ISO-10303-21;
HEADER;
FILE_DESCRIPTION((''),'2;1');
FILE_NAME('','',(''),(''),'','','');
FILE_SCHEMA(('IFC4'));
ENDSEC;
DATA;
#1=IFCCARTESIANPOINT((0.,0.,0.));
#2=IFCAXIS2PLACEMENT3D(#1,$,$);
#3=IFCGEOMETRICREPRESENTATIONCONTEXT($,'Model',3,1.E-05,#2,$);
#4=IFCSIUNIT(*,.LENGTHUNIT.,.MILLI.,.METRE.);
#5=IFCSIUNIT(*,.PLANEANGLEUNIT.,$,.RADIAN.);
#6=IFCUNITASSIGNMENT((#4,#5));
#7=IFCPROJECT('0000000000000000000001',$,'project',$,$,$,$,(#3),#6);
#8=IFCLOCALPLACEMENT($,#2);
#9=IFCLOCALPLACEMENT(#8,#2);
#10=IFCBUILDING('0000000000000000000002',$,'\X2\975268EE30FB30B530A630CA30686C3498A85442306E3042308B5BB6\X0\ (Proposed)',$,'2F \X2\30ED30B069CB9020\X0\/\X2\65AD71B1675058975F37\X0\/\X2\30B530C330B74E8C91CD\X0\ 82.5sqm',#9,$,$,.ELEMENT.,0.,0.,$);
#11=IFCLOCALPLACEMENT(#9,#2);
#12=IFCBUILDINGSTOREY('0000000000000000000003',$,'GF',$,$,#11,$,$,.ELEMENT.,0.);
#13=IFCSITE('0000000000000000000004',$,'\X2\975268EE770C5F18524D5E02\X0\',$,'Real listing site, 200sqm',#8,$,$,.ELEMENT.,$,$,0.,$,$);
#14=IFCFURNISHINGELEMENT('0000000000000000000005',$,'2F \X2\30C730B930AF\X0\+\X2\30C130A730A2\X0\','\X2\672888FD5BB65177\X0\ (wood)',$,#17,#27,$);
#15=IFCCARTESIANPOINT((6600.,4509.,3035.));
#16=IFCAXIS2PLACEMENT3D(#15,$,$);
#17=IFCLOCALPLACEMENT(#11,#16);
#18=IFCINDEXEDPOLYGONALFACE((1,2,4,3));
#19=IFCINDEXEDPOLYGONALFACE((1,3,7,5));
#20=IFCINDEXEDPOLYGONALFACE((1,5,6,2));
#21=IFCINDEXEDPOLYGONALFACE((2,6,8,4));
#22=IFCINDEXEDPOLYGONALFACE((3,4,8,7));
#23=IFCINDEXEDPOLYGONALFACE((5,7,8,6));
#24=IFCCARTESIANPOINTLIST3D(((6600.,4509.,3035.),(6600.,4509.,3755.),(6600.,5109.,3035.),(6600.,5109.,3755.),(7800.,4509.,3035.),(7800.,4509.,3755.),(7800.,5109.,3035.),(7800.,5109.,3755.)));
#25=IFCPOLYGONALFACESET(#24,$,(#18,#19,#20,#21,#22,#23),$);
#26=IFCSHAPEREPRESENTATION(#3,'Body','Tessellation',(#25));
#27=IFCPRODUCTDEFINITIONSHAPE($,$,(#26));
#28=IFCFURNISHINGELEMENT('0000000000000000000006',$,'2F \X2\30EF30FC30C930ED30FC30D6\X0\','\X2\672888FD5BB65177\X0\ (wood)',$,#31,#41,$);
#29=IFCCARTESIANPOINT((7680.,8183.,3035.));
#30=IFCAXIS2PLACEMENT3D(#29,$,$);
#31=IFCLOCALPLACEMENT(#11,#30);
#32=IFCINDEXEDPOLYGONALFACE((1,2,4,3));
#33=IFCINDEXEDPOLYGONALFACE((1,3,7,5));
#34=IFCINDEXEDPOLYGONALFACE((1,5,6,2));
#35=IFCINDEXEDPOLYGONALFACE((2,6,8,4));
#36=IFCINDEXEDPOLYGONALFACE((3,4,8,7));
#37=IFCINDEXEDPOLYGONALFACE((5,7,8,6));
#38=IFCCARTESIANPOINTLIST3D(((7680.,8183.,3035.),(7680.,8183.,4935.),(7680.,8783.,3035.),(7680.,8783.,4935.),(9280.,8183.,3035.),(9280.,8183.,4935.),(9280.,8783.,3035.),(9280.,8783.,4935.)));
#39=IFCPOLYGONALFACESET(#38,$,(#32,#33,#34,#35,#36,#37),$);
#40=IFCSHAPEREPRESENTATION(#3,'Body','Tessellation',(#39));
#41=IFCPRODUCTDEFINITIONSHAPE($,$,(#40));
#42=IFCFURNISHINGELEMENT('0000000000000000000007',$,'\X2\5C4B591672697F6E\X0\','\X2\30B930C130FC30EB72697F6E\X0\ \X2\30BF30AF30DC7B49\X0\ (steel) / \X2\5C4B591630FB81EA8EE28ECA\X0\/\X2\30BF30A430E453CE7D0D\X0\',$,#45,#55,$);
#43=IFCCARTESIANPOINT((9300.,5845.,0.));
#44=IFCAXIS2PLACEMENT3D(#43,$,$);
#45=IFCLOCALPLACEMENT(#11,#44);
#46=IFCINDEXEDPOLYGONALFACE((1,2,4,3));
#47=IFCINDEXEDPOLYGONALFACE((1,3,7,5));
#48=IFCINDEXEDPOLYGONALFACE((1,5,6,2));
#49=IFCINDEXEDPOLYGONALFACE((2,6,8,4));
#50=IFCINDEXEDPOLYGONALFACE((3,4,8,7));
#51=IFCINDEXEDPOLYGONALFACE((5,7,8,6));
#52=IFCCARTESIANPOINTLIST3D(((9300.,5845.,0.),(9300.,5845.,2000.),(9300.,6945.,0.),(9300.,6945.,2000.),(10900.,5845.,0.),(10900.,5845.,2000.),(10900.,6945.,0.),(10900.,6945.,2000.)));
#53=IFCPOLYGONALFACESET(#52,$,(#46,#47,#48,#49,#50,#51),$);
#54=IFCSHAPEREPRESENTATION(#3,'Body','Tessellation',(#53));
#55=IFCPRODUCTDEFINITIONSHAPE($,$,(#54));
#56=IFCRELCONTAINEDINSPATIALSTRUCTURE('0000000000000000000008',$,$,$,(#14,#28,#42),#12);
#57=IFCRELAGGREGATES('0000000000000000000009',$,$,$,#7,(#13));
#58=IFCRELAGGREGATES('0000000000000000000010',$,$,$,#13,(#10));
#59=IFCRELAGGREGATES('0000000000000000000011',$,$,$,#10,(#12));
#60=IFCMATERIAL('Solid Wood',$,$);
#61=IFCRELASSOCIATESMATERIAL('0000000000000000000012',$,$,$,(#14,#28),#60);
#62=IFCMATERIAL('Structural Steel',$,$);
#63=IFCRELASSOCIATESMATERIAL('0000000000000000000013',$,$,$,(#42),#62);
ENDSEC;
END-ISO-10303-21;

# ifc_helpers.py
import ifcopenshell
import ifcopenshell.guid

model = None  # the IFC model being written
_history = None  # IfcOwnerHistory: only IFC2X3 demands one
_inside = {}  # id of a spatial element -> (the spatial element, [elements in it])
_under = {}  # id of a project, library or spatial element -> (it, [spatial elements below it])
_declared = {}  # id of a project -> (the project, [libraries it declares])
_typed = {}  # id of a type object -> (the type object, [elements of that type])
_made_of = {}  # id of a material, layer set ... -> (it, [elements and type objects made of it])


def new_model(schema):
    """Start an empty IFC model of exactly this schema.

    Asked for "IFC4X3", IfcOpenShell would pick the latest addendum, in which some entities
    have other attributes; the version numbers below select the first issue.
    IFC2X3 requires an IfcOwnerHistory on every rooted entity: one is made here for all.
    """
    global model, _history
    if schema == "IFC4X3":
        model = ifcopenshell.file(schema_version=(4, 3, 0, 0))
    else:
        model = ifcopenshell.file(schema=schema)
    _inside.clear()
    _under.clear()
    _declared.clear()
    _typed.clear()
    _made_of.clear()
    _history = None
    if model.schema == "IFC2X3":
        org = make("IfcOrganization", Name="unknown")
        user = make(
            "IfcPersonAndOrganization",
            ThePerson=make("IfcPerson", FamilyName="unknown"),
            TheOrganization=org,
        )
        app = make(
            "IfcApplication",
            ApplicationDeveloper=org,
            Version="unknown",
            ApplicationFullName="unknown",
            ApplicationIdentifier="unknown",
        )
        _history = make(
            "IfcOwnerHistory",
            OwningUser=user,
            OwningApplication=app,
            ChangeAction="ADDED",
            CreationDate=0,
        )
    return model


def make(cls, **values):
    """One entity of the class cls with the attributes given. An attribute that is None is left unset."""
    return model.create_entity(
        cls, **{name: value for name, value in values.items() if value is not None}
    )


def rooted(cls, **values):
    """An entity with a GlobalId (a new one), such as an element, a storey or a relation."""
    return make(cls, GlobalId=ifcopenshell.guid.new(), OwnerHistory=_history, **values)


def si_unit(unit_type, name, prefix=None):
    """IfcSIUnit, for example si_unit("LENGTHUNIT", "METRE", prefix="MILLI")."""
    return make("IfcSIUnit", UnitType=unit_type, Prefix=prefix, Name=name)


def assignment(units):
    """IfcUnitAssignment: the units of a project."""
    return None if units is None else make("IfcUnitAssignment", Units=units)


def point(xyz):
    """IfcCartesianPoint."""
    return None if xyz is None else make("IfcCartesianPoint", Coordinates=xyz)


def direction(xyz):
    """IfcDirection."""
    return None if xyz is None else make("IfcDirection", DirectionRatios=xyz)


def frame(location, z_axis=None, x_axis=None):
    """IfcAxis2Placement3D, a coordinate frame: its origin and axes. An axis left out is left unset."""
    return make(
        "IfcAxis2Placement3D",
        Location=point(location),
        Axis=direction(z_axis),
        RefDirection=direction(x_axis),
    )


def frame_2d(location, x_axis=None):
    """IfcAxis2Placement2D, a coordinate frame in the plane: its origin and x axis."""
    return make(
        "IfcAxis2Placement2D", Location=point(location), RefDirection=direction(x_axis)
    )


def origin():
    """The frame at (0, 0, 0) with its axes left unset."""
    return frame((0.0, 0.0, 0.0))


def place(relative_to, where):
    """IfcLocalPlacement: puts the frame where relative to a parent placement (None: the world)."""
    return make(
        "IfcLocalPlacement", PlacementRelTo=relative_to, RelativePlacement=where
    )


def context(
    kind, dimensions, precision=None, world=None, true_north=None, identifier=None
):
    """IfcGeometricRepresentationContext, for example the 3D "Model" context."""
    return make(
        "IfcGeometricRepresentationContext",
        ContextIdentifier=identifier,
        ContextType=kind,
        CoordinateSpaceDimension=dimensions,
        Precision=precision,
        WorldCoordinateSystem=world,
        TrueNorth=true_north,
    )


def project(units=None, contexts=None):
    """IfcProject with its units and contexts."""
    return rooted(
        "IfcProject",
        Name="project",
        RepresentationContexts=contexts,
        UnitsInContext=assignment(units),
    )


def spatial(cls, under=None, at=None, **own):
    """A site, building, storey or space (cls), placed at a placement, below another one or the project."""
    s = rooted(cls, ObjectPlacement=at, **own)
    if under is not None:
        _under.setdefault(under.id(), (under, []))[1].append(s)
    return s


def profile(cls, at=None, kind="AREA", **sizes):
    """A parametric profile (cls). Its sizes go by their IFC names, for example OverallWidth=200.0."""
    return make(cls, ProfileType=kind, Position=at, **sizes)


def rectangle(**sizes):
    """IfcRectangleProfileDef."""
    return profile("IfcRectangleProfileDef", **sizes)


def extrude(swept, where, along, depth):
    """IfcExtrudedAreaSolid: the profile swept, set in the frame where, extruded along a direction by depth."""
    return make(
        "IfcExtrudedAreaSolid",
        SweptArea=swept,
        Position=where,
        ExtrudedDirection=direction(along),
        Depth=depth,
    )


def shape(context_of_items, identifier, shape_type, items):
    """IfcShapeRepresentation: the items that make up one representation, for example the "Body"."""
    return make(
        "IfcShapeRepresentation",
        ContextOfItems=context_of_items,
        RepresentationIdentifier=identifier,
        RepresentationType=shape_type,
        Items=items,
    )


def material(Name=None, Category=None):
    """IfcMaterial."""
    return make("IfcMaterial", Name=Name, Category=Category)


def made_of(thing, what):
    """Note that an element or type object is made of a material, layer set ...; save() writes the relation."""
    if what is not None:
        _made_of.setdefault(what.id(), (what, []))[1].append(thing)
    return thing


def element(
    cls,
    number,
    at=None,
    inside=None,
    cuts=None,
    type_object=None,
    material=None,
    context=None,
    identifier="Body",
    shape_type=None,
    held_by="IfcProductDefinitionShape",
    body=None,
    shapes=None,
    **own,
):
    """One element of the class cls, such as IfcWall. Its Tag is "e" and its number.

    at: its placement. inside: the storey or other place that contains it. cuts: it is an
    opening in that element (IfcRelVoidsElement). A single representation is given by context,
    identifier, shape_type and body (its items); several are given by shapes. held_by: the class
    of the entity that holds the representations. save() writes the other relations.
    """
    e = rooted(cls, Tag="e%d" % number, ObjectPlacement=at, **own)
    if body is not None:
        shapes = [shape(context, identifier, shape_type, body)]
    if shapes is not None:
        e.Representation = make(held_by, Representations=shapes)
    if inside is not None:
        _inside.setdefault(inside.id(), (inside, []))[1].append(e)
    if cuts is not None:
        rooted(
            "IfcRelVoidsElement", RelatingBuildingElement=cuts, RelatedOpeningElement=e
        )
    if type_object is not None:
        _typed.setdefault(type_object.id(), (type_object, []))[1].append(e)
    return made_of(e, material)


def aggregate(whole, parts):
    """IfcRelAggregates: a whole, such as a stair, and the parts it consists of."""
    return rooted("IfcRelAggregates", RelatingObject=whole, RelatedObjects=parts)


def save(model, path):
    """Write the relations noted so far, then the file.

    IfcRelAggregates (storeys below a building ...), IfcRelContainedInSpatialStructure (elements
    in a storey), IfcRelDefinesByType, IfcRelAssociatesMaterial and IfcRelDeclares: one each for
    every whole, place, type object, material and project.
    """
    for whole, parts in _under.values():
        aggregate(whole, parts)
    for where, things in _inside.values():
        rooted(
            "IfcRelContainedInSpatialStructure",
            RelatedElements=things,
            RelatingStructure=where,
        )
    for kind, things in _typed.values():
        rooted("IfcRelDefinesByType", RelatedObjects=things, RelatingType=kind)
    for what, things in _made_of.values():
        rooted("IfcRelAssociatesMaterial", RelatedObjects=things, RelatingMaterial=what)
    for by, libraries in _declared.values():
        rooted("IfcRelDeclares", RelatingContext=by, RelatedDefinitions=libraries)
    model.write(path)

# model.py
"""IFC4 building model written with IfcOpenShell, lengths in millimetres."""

from ifc_helpers import new_model, si_unit, frame, frame_2d, origin, place, context, project, spatial, rectangle, extrude, material, element, save


model = new_model("IFC4")

# Units and contexts
model_context = context("Model", 3, precision=1e-05, world=origin())
ifc_project = project(units=[si_unit("LENGTHUNIT", "METRE", prefix="MILLI"), si_unit("PLANEANGLEUNIT", "RADIAN")], contexts=[model_context])

# Site, building, storey
site_placement = place(None, origin())
site = spatial("IfcSite", under=ifc_project, at=site_placement, Name="青森県弘前市", ObjectType="Real listing site, 200sqm", CompositionType="ELEMENT", RefElevation=0.0)
building_placement = place(site_placement, origin())
building = spatial("IfcBuilding", under=site, at=building_placement, Name="青森・サウナと水風呂のある家 (Proposed)", ObjectType="2F ログ構造/断熱材増強/サッシ二重 82.5sqm", CompositionType="ELEMENT", ElevationOfRefHeight=0.0, ElevationOfTerrain=0.0)
storey_placement = place(building_placement, origin())
storey = spatial("IfcBuildingStorey", under=building, at=storey_placement, Name="GF", CompositionType="ELEMENT", Elevation=0.0)

# Shared definitions
ifc_material_1 = material(Name="Solid Wood")

# Shared definitions
ifc_material_2 = material(Name="Structural Steel")

# Furnishing elements
furnishing_1_placement = place(storey_placement, frame((6600.0, 4509.0, 3035.0)))
element("IfcFurnishingElement", 1, at=furnishing_1_placement, inside=storey, material=ifc_material_1, Name="2F デスク+チェア", Description="木製家具 (wood)", context=model_context, shape_type="SweptSolid", body=[
    extrude(rectangle(XDim=1200.0, YDim=600.0, at=frame_2d((600.0, 300.0))), frame((6600.0, 4509.0, 3035.0)), (0.0, 0.0, 1.0), 720.0),
])
furnishing_2_placement = place(storey_placement, frame((7680.0, 8183.0, 3035.0)))
element("IfcFurnishingElement", 2, at=furnishing_2_placement, inside=storey, material=ifc_material_1, Name="2F ワードローブ", Description="木製家具 (wood)", context=model_context, shape_type="SweptSolid", body=[
    extrude(rectangle(XDim=1600.0, YDim=600.0, at=frame_2d((800.0, 300.0))), frame((7680.0, 8183.0, 3035.0)), (0.0, 0.0, 1.0), 1900.0),
])
furnishing_3_placement = place(storey_placement, frame((9300.0, 5845.0, 0.0)))
element("IfcFurnishingElement", 3, at=furnishing_3_placement, inside=storey, material=ifc_material_2, Name="屋外物置", Description="スチール物置 タクボ等 (steel) / 屋外・自転車/タイヤ収納", context=model_context, shape_type="SweptSolid", body=[
    extrude(rectangle(XDim=1600.0, YDim=1100.0, at=frame_2d((800.0, 550.0))), frame((9300.0, 5845.0, 0.0)), (0.0, 0.0, 1.0), 2000.0),
])

save(model, "model.ifc")
